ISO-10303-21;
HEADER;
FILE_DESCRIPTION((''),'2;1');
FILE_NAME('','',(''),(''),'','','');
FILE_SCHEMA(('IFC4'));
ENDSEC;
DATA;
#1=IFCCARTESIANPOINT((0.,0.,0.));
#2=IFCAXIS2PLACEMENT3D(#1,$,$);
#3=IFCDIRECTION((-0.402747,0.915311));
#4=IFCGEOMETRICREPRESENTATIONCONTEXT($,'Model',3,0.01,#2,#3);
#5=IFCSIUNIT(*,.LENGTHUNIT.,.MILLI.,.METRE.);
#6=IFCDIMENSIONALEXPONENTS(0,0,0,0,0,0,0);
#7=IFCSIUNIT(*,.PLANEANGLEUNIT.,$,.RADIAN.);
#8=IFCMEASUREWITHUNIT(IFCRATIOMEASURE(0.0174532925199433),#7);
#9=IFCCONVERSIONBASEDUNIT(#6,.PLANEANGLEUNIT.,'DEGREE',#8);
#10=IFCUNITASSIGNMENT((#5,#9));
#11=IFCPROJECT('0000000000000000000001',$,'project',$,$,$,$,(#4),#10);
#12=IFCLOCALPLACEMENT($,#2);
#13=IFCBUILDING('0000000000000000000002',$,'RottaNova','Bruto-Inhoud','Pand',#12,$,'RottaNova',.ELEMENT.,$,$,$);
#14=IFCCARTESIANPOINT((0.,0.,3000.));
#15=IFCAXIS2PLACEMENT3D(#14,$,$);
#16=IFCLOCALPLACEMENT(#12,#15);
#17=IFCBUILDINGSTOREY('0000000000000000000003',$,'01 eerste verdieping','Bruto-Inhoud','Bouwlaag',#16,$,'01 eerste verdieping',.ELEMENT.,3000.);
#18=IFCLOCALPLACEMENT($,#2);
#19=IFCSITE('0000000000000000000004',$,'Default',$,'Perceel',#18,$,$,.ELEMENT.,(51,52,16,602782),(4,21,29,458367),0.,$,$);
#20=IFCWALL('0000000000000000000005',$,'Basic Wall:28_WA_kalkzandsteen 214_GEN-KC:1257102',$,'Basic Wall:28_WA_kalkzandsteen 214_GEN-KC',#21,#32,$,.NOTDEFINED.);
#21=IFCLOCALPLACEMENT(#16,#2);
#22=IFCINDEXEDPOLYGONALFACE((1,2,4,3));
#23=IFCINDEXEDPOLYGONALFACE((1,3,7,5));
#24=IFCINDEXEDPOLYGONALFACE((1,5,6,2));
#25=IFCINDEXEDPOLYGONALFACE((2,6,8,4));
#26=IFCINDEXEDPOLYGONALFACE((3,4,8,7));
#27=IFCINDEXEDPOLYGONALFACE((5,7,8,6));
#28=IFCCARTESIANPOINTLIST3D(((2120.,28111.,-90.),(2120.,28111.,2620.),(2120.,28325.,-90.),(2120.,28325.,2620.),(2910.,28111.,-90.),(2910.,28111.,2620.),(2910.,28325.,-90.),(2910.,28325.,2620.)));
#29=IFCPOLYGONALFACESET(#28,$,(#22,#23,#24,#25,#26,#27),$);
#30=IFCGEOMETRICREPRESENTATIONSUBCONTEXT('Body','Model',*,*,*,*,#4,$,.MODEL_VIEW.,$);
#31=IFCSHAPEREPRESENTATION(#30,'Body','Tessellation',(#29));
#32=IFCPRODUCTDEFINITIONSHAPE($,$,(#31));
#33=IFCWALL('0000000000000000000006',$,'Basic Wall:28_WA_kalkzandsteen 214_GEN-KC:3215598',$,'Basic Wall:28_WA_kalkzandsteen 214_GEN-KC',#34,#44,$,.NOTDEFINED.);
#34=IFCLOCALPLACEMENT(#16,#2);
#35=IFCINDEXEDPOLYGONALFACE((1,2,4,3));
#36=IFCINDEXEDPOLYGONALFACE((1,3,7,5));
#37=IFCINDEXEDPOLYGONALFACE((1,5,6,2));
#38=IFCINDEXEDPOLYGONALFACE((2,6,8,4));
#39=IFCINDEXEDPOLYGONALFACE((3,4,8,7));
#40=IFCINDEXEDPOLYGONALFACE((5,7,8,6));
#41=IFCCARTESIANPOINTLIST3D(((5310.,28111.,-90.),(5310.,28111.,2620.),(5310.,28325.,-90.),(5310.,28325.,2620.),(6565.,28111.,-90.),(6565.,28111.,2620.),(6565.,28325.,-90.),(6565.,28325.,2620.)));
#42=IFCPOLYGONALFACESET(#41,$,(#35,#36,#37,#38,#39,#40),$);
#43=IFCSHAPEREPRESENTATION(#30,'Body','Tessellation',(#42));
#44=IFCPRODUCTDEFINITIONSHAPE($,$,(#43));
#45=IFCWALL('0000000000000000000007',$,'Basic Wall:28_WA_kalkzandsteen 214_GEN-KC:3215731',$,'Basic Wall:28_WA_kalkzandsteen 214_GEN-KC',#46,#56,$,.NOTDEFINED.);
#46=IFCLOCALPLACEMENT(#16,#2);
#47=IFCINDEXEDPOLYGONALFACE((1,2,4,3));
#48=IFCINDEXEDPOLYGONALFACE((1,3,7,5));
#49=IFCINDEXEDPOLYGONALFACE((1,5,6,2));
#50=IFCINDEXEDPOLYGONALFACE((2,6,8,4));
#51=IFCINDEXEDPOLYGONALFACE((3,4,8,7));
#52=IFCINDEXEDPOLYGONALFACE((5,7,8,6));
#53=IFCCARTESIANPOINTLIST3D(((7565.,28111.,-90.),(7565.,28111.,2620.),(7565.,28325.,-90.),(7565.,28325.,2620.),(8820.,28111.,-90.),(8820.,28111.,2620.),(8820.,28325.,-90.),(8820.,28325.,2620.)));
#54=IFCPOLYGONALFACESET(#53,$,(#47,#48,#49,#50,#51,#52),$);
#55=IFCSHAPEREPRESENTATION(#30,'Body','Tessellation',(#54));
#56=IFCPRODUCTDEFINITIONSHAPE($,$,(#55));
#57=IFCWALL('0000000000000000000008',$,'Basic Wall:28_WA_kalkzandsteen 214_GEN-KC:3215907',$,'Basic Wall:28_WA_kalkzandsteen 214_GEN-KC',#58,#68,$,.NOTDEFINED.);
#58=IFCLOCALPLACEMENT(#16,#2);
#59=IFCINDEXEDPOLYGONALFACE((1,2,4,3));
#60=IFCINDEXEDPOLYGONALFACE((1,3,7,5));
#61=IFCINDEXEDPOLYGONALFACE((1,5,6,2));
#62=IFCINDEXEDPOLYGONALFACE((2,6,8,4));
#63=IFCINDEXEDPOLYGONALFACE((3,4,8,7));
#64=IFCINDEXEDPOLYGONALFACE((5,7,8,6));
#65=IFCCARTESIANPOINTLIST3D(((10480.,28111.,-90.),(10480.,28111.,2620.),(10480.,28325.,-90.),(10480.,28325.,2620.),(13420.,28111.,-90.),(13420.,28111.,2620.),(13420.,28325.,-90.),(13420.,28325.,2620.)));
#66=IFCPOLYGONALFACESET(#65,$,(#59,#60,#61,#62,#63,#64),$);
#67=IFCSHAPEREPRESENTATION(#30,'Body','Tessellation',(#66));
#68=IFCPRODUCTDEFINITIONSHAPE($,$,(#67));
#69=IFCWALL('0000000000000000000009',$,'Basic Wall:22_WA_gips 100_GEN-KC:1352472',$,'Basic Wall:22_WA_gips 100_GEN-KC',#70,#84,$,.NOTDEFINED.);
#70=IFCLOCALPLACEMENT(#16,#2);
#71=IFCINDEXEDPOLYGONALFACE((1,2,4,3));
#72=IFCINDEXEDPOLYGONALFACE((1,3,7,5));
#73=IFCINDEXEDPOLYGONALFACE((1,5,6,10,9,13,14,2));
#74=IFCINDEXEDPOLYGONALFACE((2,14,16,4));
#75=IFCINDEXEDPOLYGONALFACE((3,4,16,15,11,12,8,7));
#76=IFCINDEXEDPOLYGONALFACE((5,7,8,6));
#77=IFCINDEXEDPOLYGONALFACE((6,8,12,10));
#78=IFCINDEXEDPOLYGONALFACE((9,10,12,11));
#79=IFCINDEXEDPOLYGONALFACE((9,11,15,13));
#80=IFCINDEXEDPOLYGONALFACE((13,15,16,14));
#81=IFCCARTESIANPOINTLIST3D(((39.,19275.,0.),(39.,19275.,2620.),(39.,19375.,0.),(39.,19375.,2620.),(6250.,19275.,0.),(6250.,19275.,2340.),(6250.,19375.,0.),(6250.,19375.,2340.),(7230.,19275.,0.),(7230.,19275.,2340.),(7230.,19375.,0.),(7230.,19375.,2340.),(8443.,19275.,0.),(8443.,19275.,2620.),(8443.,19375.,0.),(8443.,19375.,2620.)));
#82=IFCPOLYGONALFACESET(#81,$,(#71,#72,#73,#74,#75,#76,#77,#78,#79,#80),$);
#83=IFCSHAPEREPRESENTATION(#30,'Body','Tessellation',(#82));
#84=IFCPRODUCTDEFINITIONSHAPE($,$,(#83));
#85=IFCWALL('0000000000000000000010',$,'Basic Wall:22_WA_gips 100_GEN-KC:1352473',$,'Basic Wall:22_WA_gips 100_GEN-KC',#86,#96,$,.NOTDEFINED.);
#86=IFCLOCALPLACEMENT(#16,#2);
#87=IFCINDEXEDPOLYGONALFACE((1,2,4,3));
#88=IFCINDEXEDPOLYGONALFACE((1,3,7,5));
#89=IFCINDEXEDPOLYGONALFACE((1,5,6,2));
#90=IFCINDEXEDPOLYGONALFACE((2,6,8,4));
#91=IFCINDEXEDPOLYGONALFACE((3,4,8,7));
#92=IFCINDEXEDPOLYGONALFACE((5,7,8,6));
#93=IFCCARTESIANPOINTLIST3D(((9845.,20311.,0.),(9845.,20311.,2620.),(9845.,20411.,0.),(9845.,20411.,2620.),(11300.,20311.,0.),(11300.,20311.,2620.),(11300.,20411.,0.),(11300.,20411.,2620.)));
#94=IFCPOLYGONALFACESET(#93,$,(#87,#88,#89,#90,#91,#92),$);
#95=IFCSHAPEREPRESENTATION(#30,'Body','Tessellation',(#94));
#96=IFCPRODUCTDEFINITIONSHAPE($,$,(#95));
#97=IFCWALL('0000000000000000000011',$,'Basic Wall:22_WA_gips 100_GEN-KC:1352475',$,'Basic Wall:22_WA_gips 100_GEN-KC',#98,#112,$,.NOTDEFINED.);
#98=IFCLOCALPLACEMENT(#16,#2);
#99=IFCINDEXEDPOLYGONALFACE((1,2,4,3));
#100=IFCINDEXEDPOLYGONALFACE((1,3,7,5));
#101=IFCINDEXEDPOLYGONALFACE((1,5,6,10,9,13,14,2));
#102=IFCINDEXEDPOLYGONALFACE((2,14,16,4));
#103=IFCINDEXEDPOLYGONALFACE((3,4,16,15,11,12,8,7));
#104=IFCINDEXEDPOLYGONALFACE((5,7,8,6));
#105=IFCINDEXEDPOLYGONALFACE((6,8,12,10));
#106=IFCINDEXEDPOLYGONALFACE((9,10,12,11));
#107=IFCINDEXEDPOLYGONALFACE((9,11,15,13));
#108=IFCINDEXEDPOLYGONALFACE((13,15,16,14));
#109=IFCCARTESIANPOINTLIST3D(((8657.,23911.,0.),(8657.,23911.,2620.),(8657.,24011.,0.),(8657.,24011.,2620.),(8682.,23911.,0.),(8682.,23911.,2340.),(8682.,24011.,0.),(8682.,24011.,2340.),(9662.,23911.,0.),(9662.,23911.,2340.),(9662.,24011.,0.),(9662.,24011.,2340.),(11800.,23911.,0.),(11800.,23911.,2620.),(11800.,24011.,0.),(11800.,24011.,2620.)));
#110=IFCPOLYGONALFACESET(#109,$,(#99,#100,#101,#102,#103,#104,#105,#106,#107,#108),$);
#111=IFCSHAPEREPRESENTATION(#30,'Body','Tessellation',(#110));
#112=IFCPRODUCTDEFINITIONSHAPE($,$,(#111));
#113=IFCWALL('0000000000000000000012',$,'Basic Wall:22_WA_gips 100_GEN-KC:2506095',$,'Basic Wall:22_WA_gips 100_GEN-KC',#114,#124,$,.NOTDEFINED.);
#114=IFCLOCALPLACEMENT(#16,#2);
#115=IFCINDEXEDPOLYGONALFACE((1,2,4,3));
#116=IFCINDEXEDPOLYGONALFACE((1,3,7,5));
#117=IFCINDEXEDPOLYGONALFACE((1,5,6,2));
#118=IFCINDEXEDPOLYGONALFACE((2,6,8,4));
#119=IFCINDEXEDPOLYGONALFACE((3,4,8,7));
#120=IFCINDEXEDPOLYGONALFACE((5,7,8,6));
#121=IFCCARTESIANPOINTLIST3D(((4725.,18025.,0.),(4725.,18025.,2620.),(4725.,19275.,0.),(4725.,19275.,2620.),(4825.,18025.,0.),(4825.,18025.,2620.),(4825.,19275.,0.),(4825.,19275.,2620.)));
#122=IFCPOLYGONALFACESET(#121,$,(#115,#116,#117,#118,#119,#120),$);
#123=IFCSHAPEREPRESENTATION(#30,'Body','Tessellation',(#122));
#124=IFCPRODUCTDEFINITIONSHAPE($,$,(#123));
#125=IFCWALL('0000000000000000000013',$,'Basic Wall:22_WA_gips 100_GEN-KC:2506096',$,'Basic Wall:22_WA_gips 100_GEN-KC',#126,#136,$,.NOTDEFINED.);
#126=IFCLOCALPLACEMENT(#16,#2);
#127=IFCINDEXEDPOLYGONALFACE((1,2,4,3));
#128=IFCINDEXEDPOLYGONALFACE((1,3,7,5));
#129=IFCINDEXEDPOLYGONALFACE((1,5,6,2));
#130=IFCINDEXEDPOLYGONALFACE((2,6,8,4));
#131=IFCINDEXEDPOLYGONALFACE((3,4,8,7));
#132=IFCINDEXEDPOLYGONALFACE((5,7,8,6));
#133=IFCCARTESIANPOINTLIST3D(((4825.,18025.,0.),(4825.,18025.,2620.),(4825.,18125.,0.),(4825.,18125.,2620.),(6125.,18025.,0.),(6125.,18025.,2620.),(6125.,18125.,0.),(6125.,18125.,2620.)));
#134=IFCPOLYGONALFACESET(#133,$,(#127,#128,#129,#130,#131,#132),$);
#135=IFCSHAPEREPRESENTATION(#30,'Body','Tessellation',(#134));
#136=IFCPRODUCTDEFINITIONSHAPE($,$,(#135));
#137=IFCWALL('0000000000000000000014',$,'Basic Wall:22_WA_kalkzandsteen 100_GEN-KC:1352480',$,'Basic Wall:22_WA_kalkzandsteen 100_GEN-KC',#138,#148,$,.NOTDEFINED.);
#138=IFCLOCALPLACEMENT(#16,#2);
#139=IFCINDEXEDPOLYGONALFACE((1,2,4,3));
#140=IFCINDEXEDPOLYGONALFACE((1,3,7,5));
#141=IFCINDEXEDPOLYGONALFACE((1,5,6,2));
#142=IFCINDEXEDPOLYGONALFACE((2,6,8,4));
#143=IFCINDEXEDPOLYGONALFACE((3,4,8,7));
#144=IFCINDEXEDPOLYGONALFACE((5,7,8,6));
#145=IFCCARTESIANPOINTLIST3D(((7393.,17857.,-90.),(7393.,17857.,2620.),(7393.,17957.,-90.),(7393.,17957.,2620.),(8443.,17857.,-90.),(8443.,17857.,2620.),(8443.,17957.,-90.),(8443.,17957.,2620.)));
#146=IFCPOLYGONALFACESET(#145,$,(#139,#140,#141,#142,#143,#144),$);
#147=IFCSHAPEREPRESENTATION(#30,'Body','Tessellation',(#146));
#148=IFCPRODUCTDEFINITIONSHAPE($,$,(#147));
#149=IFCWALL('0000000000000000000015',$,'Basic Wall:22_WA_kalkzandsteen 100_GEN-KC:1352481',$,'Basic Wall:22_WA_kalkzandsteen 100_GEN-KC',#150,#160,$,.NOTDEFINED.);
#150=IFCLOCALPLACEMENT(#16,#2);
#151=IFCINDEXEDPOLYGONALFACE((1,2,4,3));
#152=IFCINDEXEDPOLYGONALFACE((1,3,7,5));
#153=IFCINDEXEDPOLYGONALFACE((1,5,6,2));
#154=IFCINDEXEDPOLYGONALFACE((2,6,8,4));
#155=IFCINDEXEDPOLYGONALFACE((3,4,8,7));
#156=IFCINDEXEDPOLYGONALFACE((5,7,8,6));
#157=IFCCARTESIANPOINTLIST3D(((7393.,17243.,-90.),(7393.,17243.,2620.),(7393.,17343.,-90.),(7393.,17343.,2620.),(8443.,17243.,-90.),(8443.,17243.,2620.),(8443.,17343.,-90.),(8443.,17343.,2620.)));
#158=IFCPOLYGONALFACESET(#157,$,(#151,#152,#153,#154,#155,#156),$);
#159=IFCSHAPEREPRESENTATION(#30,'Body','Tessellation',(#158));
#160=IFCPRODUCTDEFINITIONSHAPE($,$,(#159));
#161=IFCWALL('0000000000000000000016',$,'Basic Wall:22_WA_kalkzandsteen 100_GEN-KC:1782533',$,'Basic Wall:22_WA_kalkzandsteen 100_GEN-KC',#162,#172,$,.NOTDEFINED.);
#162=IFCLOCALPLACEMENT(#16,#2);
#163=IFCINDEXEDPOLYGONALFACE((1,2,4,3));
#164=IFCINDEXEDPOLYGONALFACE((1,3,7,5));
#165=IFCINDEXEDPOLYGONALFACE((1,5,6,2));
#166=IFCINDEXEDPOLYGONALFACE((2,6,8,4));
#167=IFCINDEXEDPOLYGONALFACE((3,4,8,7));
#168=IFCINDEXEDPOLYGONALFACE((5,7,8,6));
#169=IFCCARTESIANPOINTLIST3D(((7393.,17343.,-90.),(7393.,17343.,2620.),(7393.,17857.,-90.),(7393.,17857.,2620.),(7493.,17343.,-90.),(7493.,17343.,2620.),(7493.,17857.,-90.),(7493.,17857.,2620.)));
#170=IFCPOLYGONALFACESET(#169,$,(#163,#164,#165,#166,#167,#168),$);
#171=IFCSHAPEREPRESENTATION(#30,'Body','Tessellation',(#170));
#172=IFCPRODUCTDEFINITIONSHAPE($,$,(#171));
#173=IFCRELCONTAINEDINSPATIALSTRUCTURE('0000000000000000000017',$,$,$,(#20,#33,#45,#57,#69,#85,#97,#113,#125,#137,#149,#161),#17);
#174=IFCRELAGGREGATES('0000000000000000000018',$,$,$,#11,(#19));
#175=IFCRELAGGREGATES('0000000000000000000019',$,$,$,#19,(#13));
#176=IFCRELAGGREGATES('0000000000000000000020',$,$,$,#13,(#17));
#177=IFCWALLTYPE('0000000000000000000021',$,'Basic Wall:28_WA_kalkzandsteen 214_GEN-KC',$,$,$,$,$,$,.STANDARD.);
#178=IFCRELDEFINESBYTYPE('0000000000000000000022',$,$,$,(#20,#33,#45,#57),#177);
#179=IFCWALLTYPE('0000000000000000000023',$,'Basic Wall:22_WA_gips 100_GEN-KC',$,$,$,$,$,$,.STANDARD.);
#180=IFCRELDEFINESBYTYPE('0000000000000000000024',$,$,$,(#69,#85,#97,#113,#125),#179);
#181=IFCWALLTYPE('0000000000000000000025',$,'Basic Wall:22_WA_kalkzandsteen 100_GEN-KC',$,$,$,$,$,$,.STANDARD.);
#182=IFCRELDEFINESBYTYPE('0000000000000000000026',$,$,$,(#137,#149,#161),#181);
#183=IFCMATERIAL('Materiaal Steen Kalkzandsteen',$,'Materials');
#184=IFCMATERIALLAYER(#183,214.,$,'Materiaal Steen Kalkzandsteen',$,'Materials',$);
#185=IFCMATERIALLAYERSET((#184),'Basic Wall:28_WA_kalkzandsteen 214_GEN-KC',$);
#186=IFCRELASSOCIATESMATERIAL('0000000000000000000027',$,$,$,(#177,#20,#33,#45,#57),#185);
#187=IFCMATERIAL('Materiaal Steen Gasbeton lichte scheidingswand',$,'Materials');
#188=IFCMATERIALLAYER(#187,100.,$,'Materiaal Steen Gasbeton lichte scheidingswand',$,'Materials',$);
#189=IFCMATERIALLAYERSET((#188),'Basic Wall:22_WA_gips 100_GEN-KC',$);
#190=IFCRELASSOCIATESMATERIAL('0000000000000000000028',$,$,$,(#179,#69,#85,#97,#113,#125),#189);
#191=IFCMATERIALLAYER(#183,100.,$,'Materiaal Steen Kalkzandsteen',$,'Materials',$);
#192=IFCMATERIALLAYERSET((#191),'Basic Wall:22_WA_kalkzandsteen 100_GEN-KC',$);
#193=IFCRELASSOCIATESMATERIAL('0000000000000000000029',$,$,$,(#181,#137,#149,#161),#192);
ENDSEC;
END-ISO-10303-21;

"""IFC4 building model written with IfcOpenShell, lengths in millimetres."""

from ifc_helpers import new_model, entity, si_unit, converted_unit, direction, frame, frame_2d, origin, place, context, subcontext, project, spatial, rectangle, extrude, material, layer, layer_set, type_object, element, save


model = new_model("IFC4")

# Units and contexts
model_context = context("Model", 3, precision=0.01, world=origin(), true_north=direction((-0.402747, 0.915311)))
body_context = subcontext(model_context, "Body", "Model", "MODEL_VIEW")
ifc_project = project(units=[si_unit("LENGTHUNIT", "METRE", prefix="MILLI"), converted_unit("PLANEANGLEUNIT", "DEGREE", entity("IfcRatioMeasure", 0.0174532925199433), si_unit("PLANEANGLEUNIT", "RADIAN"), dimensions=[0, 0, 0, 0, 0, 0, 0])], contexts=[model_context])

# Site, building, storey
site_placement = place(None, origin())
site = spatial("IfcSite", under=ifc_project, at=site_placement, Name="Default", ObjectType="Perceel", CompositionType="ELEMENT", RefLatitude=(51, 52, 16, 602782), RefLongitude=(4, 21, 29, 458367), RefElevation=0.0)
building_placement = place(None, origin())
building = spatial("IfcBuilding", under=site, at=building_placement, Name="RottaNova", Description="Bruto-Inhoud", ObjectType="Pand", LongName="RottaNova", CompositionType="ELEMENT")
storey_placement = place(building_placement, frame((0.0, 0.0, 3000.0)))
storey = spatial("IfcBuildingStorey", under=building, at=storey_placement, Name="01 eerste verdieping", Description="Bruto-Inhoud", ObjectType="Bouwlaag", LongName="01 eerste verdieping", CompositionType="ELEMENT", Elevation=3000.0)

# Walls
ifc_material_1 = material(Name="Materiaal Steen Kalkzandsteen", Category="Materials")
ifc_layer_1 = layer(ifc_material_1, 214.0, Name="Materiaal Steen Kalkzandsteen", Category="Materials")
ifc_layer_set_1 = layer_set([ifc_layer_1], Name="Basic Wall:28_WA_kalkzandsteen 214_GEN-KC")
wall_type_1 = type_object("IfcWallType", Name="Basic Wall:28_WA_kalkzandsteen 214_GEN-KC", PredefinedType="STANDARD", material=ifc_layer_set_1)
wall_1_placement = place(storey_placement, frame((2120.0, 28218.0, -90.0)))
element("IfcWall", 1, at=wall_1_placement, inside=storey, type_object=wall_type_1, material=ifc_layer_set_1, Name="Basic Wall:28_WA_kalkzandsteen 214_GEN-KC:1257102", ObjectType="Basic Wall:28_WA_kalkzandsteen 214_GEN-KC", PredefinedType="NOTDEFINED", context=body_context, shape_type="SweptSolid", body=[
    extrude(rectangle(XDim=790.0, YDim=214.0, at=frame_2d((395.0, 0.0), x_axis=(-1.0, 0.0))), origin(), (0.0, 0.0, 1.0), 2710.0),
])
wall_2_placement = place(storey_placement, frame((5310.0, 28218.0, -90.0)))
element("IfcWall", 2, at=wall_2_placement, inside=storey, type_object=wall_type_1, material=ifc_layer_set_1, Name="Basic Wall:28_WA_kalkzandsteen 214_GEN-KC:3215598", ObjectType="Basic Wall:28_WA_kalkzandsteen 214_GEN-KC", PredefinedType="NOTDEFINED", context=body_context, shape_type="SweptSolid", body=[
    extrude(rectangle(XDim=1255.0, YDim=214.0, at=frame_2d((627.5, 0.0), x_axis=(-1.0, 0.0))), origin(), (0.0, 0.0, 1.0), 2710.0),
])
wall_3_placement = place(storey_placement, frame((7565.0, 28218.0, -90.0)))
element("IfcWall", 3, at=wall_3_placement, inside=storey, type_object=wall_type_1, material=ifc_layer_set_1, Name="Basic Wall:28_WA_kalkzandsteen 214_GEN-KC:3215731", ObjectType="Basic Wall:28_WA_kalkzandsteen 214_GEN-KC", PredefinedType="NOTDEFINED", context=body_context, shape_type="SweptSolid", body=[
    extrude(rectangle(XDim=1255.0, YDim=214.0, at=frame_2d((627.5, 0.0), x_axis=(-1.0, 0.0))), origin(), (0.0, 0.0, 1.0), 2710.0),
])
wall_4_placement = place(storey_placement, frame((10480.0, 28218.0, -90.0)))
element("IfcWall", 4, at=wall_4_placement, inside=storey, type_object=wall_type_1, material=ifc_layer_set_1, Name="Basic Wall:28_WA_kalkzandsteen 214_GEN-KC:3215907", ObjectType="Basic Wall:28_WA_kalkzandsteen 214_GEN-KC", PredefinedType="NOTDEFINED", context=body_context, shape_type="SweptSolid", body=[
    extrude(rectangle(XDim=2940.0, YDim=214.0, at=frame_2d((1470.0, 0.0), x_axis=(-1.0, 0.0))), origin(), (0.0, 0.0, 1.0), 2710.0),
])

# Wall, opening
ifc_material_2 = material(Name="Materiaal Steen Gasbeton lichte scheidingswand", Category="Materials")
ifc_layer_2 = layer(ifc_material_2, 100.0, Name="Materiaal Steen Gasbeton lichte scheidingswand", Category="Materials")
ifc_layer_set_2 = layer_set([ifc_layer_2], Name="Basic Wall:22_WA_gips 100_GEN-KC")
wall_type_2 = type_object("IfcWallType", Name="Basic Wall:22_WA_gips 100_GEN-KC", PredefinedType="STANDARD", material=ifc_layer_set_2)
wall_5_placement = place(storey_placement, frame((39.0, 19325.0, 0.0)))
wall_5 = element("IfcWall", 5, at=wall_5_placement, inside=storey, type_object=wall_type_2, material=ifc_layer_set_2, Name="Basic Wall:22_WA_gips 100_GEN-KC:1352472", ObjectType="Basic Wall:22_WA_gips 100_GEN-KC", PredefinedType="NOTDEFINED", context=body_context, shape_type="SweptSolid", body=[
    extrude(rectangle(XDim=8404.0, YDim=100.0, at=frame_2d((4202.0, 0.0), x_axis=(-1.0, 0.0))), origin(), (0.0, 0.0, 1.0), 2620.0),
])
opening_1_placement = place(wall_5_placement, frame((6211.0, -50.0, -90.0)))
element("IfcOpeningElement", 6, at=opening_1_placement, cuts=wall_5, PredefinedType="OPENING", context=body_context, shape_type="SweptSolid", body=[
    extrude(rectangle(XDim=2430.0, YDim=980.0, at=frame_2d((1215.0, 490.0), x_axis=(1.0, 0.0))), frame((0.0, 0.0, 0.0), z_axis=(0.0, 1.0, 0.0), x_axis=(0.0, 0.0, 1.0)), (0.0, 0.0, 1.0), 100.0),
])

# Wall
wall_6_placement = place(storey_placement, frame((9845.0, 20361.0, 0.0)))
element("IfcWall", 7, at=wall_6_placement, inside=storey, type_object=wall_type_2, material=ifc_layer_set_2, Name="Basic Wall:22_WA_gips 100_GEN-KC:1352473", ObjectType="Basic Wall:22_WA_gips 100_GEN-KC", PredefinedType="NOTDEFINED", context=body_context, shape_type="SweptSolid", body=[
    extrude(rectangle(XDim=1455.0, YDim=100.0, at=frame_2d((727.5, 0.0), x_axis=(-1.0, 0.0))), origin(), (0.0, 0.0, 1.0), 2620.0),
])

# Wall, opening
wall_7_placement = place(storey_placement, frame((8657.0, 23961.0, 0.0)))
wall_7 = element("IfcWall", 8, at=wall_7_placement, inside=storey, type_object=wall_type_2, material=ifc_layer_set_2, Name="Basic Wall:22_WA_gips 100_GEN-KC:1352475", ObjectType="Basic Wall:22_WA_gips 100_GEN-KC", PredefinedType="NOTDEFINED", context=body_context, shape_type="SweptSolid", body=[
    extrude(rectangle(XDim=3143.0, YDim=100.0, at=frame_2d((1571.5, 0.0), x_axis=(-1.0, 0.0))), origin(), (0.0, 0.0, 1.0), 2620.0),
])
opening_2_placement = place(wall_7_placement, frame((25.0, -50.0, -90.0)))
element("IfcOpeningElement", 9, at=opening_2_placement, cuts=wall_7, PredefinedType="OPENING", context=body_context, shape_type="SweptSolid", body=[
    extrude(rectangle(XDim=2430.0, YDim=980.0, at=frame_2d((1215.0, 490.0), x_axis=(1.0, 0.0))), frame((0.0, 0.0, 0.0), z_axis=(0.0, 1.0, 0.0), x_axis=(0.0, 0.0, 1.0)), (0.0, 0.0, 1.0), 100.0),
])

# Walls
wall_8_placement = place(storey_placement, frame((4775.0, 19275.0, 0.0), z_axis=(0.0, 0.0, 1.0), x_axis=(0.0, -1.0, 0.0)))
element("IfcWall", 10, at=wall_8_placement, inside=storey, type_object=wall_type_2, material=ifc_layer_set_2, Name="Basic Wall:22_WA_gips 100_GEN-KC:2506095", ObjectType="Basic Wall:22_WA_gips 100_GEN-KC", PredefinedType="NOTDEFINED", context=body_context, shape_type="SweptSolid", body=[
    extrude(rectangle(XDim=1250.0, YDim=100.0, at=frame_2d((625.0, 0.0), x_axis=(-1.0, 0.0))), origin(), (0.0, 0.0, 1.0), 2620.0),
])
wall_9_placement = place(storey_placement, frame((4825.0, 18075.0, 0.0)))
element("IfcWall", 11, at=wall_9_placement, inside=storey, type_object=wall_type_2, material=ifc_layer_set_2, Name="Basic Wall:22_WA_gips 100_GEN-KC:2506096", ObjectType="Basic Wall:22_WA_gips 100_GEN-KC", PredefinedType="NOTDEFINED", context=body_context, shape_type="SweptSolid", body=[
    extrude(rectangle(XDim=1300.0, YDim=100.0, at=frame_2d((650.0, 0.0), x_axis=(-1.0, 0.0))), origin(), (0.0, 0.0, 1.0), 2620.0),
])
ifc_layer_3 = layer(ifc_material_1, 100.0, Name="Materiaal Steen Kalkzandsteen", Category="Materials")
ifc_layer_set_3 = layer_set([ifc_layer_3], Name="Basic Wall:22_WA_kalkzandsteen 100_GEN-KC")
wall_type_3 = type_object("IfcWallType", Name="Basic Wall:22_WA_kalkzandsteen 100_GEN-KC", PredefinedType="STANDARD", material=ifc_layer_set_3)
for number, where, name in (
    (12, (7393.0, 17907.0, -90.0), "Basic Wall:22_WA_kalkzandsteen 100_GEN-KC:1352480"),
    (13, (7393.0, 17293.0, -90.0), "Basic Wall:22_WA_kalkzandsteen 100_GEN-KC:1352481"),
):
    element("IfcWall", number, at=place(storey_placement, frame(where)), inside=storey, type_object=wall_type_3, material=ifc_layer_set_3, Name=name, ObjectType="Basic Wall:22_WA_kalkzandsteen 100_GEN-KC", PredefinedType="NOTDEFINED", context=body_context, shape_type="SweptSolid", body=[
        extrude(rectangle(XDim=1050.0, YDim=100.0, at=frame_2d((525.0, 0.0), x_axis=(-1.0, 0.0))), origin(), (0.0, 0.0, 1.0), 2710.0),
    ])
wall_10_placement = place(storey_placement, frame((7443.0, 17343.0, -90.0), z_axis=(0.0, 0.0, 1.0), x_axis=(0.0, 1.0, 0.0)))
element("IfcWall", 14, at=wall_10_placement, inside=storey, type_object=wall_type_3, material=ifc_layer_set_3, Name="Basic Wall:22_WA_kalkzandsteen 100_GEN-KC:1782533", ObjectType="Basic Wall:22_WA_kalkzandsteen 100_GEN-KC", PredefinedType="NOTDEFINED", context=body_context, shape_type="SweptSolid", body=[
    extrude(rectangle(XDim=514.0, YDim=100.0, at=frame_2d((257.0, 0.0), x_axis=(-1.0, 0.0))), origin(), (0.0, 0.0, 1.0), 2710.0),
])

save(model, "model.ifc")
